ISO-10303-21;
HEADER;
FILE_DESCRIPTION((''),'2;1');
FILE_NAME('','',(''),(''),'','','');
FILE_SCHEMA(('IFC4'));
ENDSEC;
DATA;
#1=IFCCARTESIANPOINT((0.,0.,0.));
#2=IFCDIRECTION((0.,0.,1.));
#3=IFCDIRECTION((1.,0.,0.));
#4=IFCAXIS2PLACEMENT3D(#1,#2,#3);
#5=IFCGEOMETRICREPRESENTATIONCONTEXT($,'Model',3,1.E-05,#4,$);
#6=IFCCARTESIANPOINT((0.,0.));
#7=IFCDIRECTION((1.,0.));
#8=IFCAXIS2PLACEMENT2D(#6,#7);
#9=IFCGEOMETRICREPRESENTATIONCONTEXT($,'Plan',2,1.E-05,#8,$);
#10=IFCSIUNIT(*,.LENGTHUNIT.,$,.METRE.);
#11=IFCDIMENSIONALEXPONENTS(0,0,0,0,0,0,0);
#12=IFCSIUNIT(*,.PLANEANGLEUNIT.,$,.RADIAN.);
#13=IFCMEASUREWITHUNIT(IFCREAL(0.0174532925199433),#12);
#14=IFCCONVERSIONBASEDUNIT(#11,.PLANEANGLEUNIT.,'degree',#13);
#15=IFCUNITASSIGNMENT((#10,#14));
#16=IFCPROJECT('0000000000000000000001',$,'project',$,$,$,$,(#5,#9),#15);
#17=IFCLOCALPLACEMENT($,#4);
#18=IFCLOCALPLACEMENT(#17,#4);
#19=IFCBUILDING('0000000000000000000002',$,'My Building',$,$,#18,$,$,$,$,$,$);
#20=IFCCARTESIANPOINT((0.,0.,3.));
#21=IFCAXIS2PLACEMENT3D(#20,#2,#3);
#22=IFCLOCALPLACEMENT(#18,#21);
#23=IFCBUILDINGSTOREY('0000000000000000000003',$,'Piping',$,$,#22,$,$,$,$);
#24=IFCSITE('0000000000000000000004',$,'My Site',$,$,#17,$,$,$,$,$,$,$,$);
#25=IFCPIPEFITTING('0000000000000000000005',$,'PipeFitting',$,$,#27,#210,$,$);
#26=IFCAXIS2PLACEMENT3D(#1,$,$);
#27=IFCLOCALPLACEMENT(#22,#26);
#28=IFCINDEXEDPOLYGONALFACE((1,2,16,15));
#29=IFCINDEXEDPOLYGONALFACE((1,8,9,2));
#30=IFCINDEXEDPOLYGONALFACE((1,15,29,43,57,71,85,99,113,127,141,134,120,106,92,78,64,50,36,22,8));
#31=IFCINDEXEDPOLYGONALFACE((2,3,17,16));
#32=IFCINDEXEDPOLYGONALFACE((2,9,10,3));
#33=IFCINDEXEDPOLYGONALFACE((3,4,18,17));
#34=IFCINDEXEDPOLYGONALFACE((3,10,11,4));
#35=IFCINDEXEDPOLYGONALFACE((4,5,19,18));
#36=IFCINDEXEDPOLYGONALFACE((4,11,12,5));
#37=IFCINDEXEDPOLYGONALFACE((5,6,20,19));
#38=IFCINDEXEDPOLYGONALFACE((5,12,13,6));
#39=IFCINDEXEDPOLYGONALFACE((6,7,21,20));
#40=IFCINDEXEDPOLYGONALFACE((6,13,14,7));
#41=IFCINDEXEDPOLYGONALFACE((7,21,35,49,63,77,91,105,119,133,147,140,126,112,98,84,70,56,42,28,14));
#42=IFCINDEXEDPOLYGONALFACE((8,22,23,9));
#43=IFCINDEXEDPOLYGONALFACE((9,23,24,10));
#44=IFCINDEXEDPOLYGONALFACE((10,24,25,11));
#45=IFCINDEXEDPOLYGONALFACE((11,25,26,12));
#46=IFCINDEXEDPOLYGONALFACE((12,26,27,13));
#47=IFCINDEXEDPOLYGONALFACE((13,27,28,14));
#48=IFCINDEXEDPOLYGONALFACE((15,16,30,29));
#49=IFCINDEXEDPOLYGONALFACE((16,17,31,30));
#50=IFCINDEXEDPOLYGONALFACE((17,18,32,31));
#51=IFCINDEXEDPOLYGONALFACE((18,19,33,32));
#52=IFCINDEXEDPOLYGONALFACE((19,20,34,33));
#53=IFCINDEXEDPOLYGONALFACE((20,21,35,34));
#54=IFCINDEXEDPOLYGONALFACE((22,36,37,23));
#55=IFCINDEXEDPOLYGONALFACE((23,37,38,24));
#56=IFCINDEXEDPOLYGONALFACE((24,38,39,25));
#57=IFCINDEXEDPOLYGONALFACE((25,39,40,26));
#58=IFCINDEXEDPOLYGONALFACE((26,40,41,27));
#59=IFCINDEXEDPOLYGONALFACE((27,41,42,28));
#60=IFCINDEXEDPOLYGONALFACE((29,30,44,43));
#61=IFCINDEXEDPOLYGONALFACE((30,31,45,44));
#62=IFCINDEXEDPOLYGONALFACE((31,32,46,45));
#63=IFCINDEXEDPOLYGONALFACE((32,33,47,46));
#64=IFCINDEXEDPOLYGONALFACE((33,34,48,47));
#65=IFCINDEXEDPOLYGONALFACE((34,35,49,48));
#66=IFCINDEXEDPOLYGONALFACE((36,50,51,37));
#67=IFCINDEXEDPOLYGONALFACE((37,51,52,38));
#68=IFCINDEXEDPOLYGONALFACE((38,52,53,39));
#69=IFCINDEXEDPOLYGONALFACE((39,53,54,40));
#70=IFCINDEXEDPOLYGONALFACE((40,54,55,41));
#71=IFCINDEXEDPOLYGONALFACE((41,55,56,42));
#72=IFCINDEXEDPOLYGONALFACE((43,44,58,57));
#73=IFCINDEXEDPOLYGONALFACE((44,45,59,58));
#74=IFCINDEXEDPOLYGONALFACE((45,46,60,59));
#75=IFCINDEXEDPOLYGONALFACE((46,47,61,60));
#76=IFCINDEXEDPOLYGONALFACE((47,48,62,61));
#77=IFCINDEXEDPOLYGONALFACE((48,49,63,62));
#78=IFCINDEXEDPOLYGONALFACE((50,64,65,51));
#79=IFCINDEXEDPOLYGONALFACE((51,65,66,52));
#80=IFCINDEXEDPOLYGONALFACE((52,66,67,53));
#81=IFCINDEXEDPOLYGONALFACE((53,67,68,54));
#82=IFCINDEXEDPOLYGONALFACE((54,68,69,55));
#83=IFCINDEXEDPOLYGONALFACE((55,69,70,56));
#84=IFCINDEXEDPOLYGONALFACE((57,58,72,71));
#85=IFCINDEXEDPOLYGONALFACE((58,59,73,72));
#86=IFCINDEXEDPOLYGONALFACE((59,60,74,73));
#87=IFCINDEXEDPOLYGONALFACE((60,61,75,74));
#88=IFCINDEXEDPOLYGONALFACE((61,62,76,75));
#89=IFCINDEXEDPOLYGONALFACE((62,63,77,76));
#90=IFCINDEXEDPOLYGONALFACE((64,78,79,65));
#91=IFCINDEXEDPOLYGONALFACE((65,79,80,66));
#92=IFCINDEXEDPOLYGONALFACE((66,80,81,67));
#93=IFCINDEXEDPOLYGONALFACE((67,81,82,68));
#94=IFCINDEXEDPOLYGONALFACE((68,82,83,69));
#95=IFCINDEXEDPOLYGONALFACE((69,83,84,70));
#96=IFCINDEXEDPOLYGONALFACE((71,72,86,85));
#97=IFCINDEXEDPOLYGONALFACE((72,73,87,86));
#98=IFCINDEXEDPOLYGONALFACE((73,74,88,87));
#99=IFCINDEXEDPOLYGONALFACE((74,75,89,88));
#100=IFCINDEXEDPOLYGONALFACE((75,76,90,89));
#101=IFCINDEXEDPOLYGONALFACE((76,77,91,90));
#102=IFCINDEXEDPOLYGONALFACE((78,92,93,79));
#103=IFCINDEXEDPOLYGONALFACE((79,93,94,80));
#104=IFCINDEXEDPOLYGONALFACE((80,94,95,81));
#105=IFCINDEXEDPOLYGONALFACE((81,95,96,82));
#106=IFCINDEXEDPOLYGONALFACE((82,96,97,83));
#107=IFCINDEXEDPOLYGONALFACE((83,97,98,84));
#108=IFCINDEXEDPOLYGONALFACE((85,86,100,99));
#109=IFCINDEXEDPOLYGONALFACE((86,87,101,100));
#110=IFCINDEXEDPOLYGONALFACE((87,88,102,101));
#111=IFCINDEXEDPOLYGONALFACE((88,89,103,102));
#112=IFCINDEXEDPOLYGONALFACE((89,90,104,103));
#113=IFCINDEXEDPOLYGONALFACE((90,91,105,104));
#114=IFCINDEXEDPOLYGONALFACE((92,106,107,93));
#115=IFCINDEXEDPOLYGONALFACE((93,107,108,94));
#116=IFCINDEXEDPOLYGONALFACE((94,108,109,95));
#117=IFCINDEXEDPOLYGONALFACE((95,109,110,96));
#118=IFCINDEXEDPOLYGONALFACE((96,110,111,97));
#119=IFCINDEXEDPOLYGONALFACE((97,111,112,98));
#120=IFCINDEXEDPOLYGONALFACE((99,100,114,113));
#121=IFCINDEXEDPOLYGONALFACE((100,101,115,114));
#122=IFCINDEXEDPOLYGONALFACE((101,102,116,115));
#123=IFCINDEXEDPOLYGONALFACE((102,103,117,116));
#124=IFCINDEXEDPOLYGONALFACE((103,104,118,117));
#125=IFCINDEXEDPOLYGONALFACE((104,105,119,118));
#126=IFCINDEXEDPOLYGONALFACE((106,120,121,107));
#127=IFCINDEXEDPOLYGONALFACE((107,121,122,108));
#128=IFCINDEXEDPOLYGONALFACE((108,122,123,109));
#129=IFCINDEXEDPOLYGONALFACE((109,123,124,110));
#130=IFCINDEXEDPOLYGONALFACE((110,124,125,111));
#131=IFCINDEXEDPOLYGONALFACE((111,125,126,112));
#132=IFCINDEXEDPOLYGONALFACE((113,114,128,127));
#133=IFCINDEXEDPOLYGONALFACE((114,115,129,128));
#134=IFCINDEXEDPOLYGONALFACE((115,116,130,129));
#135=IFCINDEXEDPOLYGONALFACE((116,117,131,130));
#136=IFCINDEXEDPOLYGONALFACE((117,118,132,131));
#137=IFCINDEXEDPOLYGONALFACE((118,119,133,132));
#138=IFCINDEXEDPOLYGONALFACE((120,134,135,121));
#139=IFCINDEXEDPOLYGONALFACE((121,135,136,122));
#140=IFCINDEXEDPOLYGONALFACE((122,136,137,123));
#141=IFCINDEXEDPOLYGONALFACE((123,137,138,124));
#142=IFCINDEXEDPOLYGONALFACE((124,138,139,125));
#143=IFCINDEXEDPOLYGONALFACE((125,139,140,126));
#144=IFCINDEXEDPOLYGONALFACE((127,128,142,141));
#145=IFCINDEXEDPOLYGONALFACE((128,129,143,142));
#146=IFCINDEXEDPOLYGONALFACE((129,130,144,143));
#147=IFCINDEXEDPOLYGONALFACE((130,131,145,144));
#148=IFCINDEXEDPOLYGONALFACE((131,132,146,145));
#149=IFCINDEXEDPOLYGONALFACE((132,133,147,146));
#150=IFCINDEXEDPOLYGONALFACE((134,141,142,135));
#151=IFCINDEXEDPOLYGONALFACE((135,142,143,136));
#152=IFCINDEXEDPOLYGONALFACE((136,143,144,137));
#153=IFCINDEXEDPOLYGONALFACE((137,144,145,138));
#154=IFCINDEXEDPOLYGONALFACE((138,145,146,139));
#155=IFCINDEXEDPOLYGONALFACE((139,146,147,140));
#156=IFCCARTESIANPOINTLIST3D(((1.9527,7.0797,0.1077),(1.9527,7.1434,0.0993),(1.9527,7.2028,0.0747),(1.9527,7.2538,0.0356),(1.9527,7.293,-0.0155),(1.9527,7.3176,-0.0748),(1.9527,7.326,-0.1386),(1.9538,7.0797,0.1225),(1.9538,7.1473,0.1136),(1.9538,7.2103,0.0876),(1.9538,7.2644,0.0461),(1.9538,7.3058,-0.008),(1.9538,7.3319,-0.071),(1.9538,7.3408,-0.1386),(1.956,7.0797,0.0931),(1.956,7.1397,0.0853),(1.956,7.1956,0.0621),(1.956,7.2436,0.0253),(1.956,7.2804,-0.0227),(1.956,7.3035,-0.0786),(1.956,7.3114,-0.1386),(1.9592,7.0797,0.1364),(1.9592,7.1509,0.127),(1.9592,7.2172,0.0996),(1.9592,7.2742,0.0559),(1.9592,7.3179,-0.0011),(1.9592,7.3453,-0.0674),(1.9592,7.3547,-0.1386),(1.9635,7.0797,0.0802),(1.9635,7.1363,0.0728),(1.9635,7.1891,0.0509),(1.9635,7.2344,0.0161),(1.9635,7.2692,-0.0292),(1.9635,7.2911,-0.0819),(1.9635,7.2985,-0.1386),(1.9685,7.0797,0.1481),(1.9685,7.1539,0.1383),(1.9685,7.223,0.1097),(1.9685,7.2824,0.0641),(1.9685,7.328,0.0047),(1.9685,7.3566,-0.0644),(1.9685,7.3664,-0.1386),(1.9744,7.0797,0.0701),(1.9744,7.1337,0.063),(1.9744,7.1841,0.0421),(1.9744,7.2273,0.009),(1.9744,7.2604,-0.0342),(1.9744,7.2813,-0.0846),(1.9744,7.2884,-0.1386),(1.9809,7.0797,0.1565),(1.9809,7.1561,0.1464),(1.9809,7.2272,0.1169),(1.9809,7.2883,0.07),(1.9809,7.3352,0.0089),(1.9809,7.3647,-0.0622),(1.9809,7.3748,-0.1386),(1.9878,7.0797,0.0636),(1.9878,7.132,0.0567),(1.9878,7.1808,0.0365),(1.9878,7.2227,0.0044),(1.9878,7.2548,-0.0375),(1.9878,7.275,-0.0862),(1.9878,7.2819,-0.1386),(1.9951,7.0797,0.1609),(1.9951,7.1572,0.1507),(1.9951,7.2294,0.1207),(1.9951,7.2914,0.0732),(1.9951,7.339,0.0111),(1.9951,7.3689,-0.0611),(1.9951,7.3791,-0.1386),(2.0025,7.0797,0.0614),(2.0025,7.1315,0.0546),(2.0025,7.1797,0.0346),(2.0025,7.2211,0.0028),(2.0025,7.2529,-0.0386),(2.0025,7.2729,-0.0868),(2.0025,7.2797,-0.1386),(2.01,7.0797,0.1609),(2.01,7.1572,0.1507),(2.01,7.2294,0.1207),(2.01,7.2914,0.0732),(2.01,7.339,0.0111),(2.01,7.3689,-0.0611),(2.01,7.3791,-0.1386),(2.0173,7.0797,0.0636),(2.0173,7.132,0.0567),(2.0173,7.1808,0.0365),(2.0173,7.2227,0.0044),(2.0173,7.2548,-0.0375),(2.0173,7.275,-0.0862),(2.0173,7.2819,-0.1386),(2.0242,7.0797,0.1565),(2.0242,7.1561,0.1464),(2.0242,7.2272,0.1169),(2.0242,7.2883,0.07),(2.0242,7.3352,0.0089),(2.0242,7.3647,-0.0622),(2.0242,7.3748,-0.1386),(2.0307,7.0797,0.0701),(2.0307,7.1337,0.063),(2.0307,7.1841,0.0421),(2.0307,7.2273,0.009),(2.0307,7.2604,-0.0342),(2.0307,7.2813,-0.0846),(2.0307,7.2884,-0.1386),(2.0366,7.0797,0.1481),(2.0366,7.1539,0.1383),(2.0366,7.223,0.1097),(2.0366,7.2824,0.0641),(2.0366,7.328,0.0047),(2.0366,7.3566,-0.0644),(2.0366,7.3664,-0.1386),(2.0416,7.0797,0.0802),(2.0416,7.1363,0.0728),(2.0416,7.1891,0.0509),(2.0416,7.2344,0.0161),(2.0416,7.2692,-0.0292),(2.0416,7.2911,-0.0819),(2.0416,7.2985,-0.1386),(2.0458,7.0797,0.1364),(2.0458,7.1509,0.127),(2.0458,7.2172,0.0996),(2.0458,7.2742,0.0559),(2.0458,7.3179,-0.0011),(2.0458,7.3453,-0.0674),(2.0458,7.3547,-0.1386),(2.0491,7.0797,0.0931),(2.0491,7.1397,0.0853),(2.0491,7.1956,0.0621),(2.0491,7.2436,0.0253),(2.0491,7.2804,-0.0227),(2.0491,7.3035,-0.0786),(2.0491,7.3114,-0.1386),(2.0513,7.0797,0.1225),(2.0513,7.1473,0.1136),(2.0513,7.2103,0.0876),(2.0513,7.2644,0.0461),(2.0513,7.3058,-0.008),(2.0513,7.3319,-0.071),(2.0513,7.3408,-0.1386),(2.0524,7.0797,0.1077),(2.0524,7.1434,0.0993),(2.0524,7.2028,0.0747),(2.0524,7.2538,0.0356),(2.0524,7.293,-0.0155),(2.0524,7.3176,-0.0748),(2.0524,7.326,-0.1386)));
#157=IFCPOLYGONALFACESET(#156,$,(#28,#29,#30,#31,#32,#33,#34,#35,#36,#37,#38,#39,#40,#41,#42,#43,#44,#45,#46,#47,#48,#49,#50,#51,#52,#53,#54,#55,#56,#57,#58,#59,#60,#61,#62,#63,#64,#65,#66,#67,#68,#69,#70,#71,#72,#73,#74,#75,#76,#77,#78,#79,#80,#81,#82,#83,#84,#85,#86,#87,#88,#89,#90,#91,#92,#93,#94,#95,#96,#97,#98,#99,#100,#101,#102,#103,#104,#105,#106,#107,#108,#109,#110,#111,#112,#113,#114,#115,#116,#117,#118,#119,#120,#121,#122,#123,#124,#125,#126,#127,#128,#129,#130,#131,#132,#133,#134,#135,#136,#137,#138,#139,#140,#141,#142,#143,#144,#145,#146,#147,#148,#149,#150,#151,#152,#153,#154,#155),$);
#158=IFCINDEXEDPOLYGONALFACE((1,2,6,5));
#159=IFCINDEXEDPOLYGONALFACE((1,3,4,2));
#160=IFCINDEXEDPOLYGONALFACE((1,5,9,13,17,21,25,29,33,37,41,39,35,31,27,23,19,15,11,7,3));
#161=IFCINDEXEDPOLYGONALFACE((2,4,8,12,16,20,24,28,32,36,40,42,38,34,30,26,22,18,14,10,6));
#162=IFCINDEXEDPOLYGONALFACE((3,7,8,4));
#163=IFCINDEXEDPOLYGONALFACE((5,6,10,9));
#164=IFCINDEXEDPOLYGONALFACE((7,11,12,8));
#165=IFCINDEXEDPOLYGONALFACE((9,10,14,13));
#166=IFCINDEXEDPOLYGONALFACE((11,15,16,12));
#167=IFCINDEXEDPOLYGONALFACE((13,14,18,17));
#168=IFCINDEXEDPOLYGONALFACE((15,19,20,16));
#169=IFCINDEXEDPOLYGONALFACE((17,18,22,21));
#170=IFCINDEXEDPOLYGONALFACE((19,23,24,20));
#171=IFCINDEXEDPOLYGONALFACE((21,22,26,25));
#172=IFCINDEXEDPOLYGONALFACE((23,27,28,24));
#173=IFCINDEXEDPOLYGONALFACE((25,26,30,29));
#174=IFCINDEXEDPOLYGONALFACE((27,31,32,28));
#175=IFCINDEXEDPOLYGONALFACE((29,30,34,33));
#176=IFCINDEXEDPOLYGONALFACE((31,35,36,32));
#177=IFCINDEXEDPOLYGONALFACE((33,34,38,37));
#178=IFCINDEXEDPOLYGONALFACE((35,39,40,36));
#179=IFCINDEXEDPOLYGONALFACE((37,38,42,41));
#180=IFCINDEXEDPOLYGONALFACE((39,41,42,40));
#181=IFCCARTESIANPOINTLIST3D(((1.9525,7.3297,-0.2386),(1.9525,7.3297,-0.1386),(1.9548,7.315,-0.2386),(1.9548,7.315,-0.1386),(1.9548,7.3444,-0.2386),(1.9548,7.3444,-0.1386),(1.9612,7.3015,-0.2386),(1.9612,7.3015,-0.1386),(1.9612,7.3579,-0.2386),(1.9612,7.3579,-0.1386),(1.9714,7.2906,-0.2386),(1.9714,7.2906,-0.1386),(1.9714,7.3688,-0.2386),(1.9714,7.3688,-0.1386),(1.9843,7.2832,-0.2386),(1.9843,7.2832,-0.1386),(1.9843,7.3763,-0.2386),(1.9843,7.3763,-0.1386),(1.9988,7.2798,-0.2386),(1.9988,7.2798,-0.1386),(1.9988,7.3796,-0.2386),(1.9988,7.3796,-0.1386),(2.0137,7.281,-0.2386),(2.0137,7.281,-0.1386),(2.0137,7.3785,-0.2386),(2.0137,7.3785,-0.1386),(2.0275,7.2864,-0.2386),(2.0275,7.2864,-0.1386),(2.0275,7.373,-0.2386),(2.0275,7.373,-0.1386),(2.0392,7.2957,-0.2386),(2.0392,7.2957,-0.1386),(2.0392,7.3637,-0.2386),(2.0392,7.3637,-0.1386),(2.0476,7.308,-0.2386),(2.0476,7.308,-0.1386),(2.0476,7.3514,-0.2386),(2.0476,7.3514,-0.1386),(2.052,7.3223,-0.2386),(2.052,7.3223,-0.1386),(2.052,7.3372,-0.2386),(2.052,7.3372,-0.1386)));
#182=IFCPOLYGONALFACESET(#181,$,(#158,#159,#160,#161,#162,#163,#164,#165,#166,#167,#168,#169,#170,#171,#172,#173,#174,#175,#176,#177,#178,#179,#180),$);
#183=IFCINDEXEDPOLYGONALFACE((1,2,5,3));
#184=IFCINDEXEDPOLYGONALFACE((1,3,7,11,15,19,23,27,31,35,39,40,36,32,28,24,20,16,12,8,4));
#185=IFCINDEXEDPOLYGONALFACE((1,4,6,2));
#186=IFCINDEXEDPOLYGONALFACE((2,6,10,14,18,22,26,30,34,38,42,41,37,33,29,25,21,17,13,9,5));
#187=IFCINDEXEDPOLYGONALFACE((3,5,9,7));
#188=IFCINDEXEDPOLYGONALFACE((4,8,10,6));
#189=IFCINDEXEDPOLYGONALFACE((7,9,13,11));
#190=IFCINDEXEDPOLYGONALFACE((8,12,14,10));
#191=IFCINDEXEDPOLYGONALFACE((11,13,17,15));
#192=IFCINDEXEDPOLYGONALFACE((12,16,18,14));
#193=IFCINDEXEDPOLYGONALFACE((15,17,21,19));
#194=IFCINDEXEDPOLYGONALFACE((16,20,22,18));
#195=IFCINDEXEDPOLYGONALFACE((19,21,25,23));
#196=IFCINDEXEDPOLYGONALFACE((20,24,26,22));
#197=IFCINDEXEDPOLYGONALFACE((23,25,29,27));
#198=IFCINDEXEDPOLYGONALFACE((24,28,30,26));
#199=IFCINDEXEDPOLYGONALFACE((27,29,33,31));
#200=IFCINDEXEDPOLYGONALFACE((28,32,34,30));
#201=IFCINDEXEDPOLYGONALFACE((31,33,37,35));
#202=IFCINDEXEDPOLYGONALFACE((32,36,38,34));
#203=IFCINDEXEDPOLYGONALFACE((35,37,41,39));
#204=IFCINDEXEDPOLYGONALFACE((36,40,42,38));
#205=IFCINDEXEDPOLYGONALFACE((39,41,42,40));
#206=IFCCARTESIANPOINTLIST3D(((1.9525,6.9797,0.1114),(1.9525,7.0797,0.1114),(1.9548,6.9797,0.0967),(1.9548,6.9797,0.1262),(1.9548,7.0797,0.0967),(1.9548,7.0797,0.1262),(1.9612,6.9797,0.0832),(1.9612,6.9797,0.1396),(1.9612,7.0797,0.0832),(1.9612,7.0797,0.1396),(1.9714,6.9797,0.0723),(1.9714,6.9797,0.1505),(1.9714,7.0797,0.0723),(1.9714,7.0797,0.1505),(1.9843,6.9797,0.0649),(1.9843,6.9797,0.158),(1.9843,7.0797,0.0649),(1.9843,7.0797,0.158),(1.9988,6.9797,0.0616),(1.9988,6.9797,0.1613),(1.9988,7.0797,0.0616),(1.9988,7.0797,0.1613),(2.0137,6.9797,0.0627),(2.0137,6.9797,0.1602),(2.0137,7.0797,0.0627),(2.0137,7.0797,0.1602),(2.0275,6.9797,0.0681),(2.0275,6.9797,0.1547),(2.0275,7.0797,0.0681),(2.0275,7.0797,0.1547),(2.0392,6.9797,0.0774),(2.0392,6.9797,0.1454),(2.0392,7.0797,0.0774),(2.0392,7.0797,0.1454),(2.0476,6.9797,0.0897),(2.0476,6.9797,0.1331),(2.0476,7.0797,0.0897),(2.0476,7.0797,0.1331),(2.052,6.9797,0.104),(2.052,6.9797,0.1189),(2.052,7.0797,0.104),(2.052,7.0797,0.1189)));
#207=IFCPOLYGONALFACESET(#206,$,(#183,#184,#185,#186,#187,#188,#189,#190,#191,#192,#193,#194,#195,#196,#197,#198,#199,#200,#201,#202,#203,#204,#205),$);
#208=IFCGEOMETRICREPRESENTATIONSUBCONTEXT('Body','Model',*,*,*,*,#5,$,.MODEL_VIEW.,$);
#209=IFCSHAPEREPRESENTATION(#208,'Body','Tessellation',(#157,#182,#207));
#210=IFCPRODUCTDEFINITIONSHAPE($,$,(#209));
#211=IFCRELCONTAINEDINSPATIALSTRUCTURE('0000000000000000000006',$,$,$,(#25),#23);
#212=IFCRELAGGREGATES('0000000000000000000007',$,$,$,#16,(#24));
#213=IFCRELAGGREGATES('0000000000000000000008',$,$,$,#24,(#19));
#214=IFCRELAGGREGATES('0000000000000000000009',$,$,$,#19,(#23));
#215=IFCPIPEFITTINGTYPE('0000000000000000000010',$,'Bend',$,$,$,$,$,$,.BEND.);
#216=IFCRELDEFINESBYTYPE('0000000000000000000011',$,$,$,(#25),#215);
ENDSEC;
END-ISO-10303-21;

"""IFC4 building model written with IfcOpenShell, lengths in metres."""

from ifc_helpers import new_model, entity, si_unit, converted_unit, frame, origin_with_axes, origin_2d_with_axis, place, context, subcontext, project, spatial, circle, extrude, source, transform, mapped, type_object, type_shapes, element, save


model = new_model("IFC4")

# Units and contexts
model_context = context("Model", 3, precision=1e-05, world=origin_with_axes())
plan_context = context("Plan", 2, precision=1e-05, world=origin_2d_with_axis())
body_context = subcontext(model_context, "Body", "Model", "MODEL_VIEW")
ifc_project = project(units=[si_unit("LENGTHUNIT", "METRE"), converted_unit("PLANEANGLEUNIT", "degree", entity("IfcReal", 0.0174532925199433), si_unit("PLANEANGLEUNIT", "RADIAN"), dimensions=[0, 0, 0, 0, 0, 0, 0])], contexts=[model_context, plan_context])

# Site, building, storey
site_placement = place(None, origin_with_axes())
site = spatial("IfcSite", under=ifc_project, at=site_placement, Name="My Site")
building_placement = place(site_placement, origin_with_axes())
building = spatial("IfcBuilding", under=site, at=building_placement, Name="My Building")
storey_placement = place(building_placement, frame((0.0, 0.0, 3.0), z_axis=(0.0, 0.0, 1.0), x_axis=(1.0, 0.0, 0.0)))
storey = spatial("IfcBuildingStorey", under=building, at=storey_placement, Name="Piping")

# Pipe fitting
pipe_fitting_type_1 = type_object("IfcPipeFittingType", Name="Bend", PredefinedType="BEND")
shared_shape = source(origin_with_axes(), body_context, "Body", "SolidModel", [
    entity("IfcSweptDiskSolid", entity("IfcIndexedPolyCurve", entity("IfcCartesianPointList3D", [[0.0, 0.0, -0.1], [0.0, -0.0732, -0.2768], [0.0, -0.25, -0.35]]), [entity("IfcArcIndex", [1, 2, 3])]), 0.05),
    extrude(circle(Radius=0.05), origin_with_axes(), (0.0, 0.0, -1.0), 0.1),
    extrude(circle(Radius=0.05), frame((0.0, -0.25, -0.35), z_axis=(0.0, -1.0, 0.0), x_axis=(1.0, 0.0, 0.0)), (0.0, 0.0, 1.0), 0.1),
])
type_shapes(pipe_fitting_type_1, [shared_shape])
for number, where, z_axis, x_axis, name in (
    (1, (2.0025, 7.3297, -0.2386), (0.0, 0.0, -1.0), (-1.0, 0.0, 0.0), "PipeFitting"),
):
    element("IfcPipeFitting", number, at=place(storey_placement, frame(where, z_axis=z_axis, x_axis=x_axis)), inside=storey, type_object=pipe_fitting_type_1, Name=name, context=body_context, shape_type="MappedRepresentation", body=[
        mapped(shared_shape, transform((0.0, 0.0, 0.0), x_axis=(1.0, 0.0, 0.0), y_axis=(0.0, 1.0, 0.0), z_axis=(0.0, 0.0, 1.0), scale=1.0)),
    ])

save(model, "model.ifc")
